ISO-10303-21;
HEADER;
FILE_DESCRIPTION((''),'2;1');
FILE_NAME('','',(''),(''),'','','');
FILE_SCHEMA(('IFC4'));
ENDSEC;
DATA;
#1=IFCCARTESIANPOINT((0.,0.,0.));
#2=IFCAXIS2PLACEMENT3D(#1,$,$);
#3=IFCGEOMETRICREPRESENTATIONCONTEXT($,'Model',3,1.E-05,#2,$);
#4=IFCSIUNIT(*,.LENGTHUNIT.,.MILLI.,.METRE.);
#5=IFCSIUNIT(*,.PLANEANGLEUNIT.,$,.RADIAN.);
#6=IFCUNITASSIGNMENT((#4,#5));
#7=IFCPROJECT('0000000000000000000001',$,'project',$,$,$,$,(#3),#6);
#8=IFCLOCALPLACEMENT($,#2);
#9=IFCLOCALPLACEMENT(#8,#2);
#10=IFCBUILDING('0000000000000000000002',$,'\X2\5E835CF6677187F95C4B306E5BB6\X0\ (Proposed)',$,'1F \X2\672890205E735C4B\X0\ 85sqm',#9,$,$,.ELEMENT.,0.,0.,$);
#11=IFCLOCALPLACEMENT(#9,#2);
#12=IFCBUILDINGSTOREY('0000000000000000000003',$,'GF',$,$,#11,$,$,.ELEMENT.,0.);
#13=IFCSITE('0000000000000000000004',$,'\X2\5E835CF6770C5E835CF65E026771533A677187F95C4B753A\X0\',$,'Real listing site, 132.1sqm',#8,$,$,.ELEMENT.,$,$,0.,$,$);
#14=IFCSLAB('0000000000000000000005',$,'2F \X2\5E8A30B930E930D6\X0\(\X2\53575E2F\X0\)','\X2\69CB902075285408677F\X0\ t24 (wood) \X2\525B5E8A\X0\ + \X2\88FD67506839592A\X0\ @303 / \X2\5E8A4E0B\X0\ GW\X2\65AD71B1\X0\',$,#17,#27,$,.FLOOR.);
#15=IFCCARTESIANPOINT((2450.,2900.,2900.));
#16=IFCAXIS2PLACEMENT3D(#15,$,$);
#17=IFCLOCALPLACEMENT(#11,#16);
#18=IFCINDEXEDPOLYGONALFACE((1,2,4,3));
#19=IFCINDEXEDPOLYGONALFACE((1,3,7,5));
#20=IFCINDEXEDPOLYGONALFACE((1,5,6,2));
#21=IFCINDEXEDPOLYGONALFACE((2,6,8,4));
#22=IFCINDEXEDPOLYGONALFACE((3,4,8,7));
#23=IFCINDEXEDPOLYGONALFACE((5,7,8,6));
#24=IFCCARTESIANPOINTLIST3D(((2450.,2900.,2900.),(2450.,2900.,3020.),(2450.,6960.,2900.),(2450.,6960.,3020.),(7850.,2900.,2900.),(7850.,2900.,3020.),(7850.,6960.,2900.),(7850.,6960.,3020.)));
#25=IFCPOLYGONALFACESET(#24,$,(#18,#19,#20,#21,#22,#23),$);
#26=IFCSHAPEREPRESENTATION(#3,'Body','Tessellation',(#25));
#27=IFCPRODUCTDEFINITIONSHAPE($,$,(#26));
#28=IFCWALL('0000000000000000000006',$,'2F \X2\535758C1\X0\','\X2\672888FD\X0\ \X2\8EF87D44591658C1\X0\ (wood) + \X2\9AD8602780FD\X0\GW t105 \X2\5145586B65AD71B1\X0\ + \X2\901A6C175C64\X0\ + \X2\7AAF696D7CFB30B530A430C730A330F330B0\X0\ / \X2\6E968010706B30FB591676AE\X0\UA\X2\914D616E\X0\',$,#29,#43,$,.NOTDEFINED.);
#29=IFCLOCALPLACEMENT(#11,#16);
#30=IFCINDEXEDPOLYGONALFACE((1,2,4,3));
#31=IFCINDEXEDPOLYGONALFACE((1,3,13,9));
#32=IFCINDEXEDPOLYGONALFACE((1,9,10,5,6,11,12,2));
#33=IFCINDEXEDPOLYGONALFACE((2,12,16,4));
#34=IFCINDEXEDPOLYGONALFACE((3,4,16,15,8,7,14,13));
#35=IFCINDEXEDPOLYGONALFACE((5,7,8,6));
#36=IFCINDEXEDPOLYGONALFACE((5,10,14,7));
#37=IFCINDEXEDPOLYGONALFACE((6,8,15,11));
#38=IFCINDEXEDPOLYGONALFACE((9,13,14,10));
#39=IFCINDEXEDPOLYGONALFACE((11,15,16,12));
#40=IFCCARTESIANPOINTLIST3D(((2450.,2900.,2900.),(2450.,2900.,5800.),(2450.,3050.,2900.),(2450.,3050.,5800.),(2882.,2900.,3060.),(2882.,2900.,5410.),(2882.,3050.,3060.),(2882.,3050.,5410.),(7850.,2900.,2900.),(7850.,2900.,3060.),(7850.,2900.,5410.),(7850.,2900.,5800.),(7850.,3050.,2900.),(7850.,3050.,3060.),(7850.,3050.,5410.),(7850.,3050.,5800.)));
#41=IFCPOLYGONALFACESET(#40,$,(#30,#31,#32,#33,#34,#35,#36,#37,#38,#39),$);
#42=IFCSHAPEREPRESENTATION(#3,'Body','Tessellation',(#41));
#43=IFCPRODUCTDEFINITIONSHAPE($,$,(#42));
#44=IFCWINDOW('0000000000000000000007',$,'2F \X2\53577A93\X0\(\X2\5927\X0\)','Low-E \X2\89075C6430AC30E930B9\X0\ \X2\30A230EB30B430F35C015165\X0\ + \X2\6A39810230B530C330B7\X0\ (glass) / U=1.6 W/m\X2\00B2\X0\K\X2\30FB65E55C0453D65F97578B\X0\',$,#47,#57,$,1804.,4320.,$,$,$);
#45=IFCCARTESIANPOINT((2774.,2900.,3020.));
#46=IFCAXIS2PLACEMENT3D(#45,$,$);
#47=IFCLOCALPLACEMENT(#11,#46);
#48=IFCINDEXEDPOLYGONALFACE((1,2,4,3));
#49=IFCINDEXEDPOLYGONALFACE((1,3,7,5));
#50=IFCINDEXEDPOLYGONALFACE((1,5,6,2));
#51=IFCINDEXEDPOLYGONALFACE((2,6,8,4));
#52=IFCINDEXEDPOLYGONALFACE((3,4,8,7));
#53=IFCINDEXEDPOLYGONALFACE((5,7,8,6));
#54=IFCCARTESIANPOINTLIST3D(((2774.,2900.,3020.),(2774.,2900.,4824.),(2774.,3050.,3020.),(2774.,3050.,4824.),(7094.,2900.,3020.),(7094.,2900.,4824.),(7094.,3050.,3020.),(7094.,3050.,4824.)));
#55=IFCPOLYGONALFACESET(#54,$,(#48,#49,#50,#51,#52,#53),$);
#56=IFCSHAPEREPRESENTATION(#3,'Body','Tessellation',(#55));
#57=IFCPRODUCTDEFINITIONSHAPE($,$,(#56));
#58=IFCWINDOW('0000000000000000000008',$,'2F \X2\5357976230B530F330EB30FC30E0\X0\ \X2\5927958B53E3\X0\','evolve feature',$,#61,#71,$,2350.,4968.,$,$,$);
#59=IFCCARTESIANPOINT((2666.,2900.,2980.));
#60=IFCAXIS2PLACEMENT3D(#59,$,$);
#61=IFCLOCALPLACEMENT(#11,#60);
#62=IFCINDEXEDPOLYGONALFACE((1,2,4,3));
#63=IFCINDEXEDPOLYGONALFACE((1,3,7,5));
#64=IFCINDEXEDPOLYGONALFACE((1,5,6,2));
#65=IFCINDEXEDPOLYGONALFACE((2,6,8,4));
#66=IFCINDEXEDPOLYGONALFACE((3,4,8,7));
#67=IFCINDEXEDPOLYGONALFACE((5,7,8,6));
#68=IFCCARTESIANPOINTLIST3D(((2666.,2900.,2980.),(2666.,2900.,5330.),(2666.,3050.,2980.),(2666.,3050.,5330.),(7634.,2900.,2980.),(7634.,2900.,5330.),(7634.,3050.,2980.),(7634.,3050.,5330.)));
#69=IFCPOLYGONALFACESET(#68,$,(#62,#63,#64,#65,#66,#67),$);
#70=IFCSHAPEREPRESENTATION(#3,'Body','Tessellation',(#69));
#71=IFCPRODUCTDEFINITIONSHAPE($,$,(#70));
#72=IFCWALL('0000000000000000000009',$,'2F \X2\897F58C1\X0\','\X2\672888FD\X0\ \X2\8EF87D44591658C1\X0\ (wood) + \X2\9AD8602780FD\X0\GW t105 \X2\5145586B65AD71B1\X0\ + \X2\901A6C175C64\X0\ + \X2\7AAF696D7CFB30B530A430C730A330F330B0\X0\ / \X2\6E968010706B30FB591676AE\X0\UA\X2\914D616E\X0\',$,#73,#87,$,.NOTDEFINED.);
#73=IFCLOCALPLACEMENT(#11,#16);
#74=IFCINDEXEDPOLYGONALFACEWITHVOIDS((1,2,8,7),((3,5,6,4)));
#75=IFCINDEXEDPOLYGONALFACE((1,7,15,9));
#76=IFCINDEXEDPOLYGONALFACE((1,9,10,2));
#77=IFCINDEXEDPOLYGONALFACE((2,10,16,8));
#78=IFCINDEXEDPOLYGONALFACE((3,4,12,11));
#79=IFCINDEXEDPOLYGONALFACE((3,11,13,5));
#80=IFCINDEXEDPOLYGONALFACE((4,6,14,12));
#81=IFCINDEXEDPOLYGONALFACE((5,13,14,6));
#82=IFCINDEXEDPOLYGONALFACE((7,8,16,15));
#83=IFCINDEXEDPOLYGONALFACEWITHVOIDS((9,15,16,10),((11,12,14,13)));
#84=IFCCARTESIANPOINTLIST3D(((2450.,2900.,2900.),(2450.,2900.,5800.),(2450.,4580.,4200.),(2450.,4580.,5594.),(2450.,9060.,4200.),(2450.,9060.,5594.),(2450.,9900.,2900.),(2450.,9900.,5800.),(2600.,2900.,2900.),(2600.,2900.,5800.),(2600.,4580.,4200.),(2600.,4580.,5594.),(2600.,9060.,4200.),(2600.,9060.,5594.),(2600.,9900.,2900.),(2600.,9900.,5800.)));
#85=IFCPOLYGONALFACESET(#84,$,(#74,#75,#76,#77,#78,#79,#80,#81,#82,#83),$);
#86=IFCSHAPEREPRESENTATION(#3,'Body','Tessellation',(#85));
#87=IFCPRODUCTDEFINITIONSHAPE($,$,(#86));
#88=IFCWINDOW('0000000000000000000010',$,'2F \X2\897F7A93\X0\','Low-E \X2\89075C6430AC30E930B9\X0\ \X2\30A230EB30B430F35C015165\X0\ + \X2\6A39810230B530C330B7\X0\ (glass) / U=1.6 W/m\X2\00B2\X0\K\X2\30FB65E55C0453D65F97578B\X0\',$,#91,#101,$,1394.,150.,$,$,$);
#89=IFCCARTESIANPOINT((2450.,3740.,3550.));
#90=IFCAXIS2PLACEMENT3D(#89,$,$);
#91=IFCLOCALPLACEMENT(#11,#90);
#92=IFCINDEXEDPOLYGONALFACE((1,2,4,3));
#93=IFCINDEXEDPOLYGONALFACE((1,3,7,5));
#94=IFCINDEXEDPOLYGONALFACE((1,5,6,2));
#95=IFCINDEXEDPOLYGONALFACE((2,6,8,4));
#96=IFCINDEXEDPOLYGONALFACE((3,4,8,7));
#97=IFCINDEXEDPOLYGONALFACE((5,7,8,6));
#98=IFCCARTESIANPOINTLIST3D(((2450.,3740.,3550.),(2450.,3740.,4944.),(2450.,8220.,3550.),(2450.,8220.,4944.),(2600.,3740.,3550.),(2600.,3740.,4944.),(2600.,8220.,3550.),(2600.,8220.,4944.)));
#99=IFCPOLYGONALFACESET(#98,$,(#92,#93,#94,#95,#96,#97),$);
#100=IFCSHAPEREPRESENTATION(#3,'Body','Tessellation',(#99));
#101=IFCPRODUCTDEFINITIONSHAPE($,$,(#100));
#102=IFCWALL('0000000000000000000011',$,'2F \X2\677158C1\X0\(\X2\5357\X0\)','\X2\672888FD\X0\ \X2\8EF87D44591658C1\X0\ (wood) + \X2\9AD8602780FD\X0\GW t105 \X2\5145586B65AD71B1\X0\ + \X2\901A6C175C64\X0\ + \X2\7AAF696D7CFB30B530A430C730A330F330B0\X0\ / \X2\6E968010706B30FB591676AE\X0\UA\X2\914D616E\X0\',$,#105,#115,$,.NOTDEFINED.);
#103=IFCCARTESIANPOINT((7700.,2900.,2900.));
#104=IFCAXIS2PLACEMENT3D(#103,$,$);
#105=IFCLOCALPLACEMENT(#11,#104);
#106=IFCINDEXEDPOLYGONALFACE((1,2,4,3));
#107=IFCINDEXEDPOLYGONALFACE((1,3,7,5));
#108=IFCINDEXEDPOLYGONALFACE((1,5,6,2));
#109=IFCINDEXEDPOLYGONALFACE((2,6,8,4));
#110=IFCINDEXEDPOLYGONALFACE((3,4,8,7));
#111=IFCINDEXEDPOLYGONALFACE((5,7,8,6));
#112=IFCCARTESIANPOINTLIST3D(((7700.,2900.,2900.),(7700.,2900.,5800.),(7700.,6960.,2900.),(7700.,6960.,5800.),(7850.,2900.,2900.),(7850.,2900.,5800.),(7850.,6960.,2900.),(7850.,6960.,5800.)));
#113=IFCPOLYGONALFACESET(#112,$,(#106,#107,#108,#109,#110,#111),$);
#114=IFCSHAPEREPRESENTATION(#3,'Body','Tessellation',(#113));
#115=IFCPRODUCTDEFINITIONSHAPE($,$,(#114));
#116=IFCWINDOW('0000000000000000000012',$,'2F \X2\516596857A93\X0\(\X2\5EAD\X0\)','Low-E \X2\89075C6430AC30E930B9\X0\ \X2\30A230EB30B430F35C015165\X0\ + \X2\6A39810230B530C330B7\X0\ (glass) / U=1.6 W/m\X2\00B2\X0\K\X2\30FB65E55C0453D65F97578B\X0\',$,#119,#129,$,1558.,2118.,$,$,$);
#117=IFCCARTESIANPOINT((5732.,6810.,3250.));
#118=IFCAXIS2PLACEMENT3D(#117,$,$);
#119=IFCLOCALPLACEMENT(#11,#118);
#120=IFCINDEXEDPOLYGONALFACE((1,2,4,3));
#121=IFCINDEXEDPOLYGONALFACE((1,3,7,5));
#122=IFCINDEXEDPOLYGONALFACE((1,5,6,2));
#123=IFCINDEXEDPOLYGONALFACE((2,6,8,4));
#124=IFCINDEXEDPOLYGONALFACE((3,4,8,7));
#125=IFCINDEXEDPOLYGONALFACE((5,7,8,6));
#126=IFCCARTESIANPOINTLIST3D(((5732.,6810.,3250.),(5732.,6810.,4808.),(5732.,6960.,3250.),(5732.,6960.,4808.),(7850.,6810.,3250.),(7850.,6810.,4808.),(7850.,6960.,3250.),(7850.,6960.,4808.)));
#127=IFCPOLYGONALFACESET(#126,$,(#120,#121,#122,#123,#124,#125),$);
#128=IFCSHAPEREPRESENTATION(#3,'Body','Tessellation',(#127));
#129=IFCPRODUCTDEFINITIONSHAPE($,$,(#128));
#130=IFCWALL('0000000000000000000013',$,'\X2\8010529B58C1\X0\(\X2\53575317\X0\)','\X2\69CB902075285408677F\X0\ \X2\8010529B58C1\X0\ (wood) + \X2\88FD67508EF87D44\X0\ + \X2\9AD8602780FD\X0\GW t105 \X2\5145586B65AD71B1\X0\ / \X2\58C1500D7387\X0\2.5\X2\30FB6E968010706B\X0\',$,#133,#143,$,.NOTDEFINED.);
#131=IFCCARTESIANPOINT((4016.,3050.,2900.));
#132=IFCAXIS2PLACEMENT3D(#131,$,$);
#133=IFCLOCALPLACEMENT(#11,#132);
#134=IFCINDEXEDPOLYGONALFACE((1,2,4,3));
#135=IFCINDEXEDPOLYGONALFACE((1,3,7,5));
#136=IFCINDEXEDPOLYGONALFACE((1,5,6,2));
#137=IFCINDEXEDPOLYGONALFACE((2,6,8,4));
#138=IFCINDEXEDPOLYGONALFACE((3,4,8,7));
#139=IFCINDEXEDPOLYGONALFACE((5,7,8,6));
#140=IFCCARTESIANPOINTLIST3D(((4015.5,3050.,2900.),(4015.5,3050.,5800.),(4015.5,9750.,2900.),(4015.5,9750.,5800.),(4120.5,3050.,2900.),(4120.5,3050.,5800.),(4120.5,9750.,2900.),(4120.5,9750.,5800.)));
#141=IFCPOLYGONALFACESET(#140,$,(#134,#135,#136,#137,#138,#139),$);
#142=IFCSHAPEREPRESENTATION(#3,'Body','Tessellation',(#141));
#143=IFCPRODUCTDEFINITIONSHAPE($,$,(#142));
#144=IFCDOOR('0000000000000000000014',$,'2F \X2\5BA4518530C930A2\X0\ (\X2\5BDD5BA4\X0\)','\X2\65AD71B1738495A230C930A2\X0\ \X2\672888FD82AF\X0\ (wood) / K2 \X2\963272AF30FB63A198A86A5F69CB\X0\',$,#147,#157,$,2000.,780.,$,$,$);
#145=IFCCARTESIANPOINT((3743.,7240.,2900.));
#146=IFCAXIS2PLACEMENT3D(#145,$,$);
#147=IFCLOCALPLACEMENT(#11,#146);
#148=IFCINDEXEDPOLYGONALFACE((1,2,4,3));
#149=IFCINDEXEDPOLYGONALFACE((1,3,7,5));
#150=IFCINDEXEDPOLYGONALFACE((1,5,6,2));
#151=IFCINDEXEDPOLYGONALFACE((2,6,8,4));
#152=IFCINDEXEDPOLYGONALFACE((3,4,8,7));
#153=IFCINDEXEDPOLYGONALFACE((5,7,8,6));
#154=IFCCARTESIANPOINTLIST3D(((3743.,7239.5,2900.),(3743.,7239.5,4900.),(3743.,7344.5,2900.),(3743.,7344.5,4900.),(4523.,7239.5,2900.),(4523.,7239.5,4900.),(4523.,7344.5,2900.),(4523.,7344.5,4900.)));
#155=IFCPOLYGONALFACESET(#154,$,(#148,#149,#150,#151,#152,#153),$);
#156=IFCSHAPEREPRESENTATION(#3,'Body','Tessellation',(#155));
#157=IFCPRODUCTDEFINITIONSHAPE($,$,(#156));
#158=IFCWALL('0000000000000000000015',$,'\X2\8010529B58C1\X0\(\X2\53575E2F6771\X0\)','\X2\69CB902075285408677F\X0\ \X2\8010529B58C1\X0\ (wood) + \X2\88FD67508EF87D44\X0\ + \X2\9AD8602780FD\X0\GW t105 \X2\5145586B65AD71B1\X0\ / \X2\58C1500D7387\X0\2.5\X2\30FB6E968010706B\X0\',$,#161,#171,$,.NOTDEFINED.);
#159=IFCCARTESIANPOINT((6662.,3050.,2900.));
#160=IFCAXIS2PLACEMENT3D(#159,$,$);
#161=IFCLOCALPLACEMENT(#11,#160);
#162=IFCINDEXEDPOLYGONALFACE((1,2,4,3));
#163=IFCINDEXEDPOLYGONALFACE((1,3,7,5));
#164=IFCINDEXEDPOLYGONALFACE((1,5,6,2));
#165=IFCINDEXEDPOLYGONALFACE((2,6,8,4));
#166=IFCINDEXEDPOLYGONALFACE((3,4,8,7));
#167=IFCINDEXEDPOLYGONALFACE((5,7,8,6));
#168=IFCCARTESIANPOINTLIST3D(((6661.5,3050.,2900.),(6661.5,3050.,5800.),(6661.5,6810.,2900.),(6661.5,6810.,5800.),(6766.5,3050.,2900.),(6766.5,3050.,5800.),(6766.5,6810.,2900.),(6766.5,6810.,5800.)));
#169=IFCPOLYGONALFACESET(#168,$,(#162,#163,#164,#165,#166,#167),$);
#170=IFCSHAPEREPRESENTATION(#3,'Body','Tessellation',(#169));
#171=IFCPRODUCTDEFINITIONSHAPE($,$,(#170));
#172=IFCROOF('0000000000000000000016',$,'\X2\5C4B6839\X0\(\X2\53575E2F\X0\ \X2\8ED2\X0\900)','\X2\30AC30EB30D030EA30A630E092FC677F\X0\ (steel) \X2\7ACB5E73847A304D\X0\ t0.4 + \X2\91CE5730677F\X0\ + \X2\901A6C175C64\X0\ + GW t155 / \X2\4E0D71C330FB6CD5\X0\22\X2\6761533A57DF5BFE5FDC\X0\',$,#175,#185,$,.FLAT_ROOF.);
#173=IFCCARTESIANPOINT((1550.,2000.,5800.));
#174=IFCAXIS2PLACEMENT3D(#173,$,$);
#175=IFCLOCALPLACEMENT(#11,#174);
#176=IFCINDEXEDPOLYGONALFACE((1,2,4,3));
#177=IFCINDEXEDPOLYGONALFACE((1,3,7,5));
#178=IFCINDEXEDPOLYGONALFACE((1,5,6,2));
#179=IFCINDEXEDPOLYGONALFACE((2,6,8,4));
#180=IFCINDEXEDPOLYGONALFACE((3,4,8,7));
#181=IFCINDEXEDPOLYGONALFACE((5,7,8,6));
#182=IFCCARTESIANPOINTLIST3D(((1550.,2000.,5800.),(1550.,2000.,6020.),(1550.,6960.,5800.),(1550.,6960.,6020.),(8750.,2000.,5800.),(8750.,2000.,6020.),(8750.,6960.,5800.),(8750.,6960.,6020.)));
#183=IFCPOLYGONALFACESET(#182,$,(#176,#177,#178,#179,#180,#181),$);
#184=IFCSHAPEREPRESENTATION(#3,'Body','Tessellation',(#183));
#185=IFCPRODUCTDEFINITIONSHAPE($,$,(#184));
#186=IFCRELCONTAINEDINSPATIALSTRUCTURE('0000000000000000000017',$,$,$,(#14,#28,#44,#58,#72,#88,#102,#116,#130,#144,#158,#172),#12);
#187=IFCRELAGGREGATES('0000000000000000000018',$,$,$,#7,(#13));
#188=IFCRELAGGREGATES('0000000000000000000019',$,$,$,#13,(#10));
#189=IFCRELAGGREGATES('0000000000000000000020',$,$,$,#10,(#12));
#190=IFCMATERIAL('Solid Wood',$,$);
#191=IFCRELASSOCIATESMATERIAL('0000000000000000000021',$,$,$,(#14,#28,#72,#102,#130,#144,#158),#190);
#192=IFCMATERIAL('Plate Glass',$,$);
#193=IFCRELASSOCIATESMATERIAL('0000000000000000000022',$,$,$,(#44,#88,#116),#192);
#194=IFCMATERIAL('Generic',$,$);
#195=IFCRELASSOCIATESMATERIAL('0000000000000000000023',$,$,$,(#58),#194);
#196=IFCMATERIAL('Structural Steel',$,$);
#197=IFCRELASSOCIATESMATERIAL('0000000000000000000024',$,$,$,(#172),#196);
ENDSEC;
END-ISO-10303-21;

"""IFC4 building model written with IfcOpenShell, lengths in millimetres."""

from ifc_helpers import new_model, si_unit, frame, frame_2d, origin, place, context, project, spatial, rectangle, extrude, material, element, fill, save


model = new_model("IFC4")

# Units and contexts
model_context = context("Model", 3, precision=1e-05, world=origin())
ifc_project = project(units=[si_unit("LENGTHUNIT", "METRE", prefix="MILLI"), si_unit("PLANEANGLEUNIT", "RADIAN")], contexts=[model_context])

# Site, building, storey
site_placement = place(None, origin())
site = spatial("IfcSite", under=ifc_project, at=site_placement, Name="広島県広島市東区東蟹屋町", ObjectType="Real listing site, 132.1sqm", CompositionType="ELEMENT", RefElevation=0.0)
building_placement = place(site_placement, origin())
building = spatial("IfcBuilding", under=site, at=building_placement, Name="広島東蟹屋の家 (Proposed)", ObjectType="1F 木造平屋 85sqm", CompositionType="ELEMENT", ElevationOfRefHeight=0.0, ElevationOfTerrain=0.0)
storey_placement = place(building_placement, origin())
storey = spatial("IfcBuildingStorey", under=building, at=storey_placement, Name="GF", CompositionType="ELEMENT", Elevation=0.0)

# Slab
ifc_material_1 = material(Name="Solid Wood")
slab_placement = place(storey_placement, frame((2450.0, 2900.0, 2900.0)))
element("IfcSlab", 1, at=slab_placement, inside=storey, material=ifc_material_1, Name="2F 床スラブ(南帯)", Description="構造用合板 t24 (wood) 剛床 + 製材根太 @303 / 床下 GW断熱", PredefinedType="FLOOR", context=model_context, shape_type="SweptSolid", body=[
    extrude(rectangle(XDim=5400.0, YDim=4060.0, at=frame_2d((2700.0, 2030.0))), frame((2450.0, 2900.0, 2900.0)), (0.0, 0.0, 1.0), 120.0),
])

# Wall, openings, windows
wall_1_placement = place(storey_placement, frame((2450.0, 2900.0, 2900.0)))
wall_1 = element("IfcWall", 2, at=wall_1_placement, inside=storey, material=ifc_material_1, Name="2F 南壁", Description="木製 軸組外壁 (wood) + 高性能GW t105 充填断熱 + 通気層 + 窯業系サイディング / 準耐火・外皮UA配慮", PredefinedType="NOTDEFINED", context=model_context, shape_type="SweptSolid", body=[
    extrude(rectangle(XDim=5400.0, YDim=150.0, at=frame_2d((2700.0, 75.0))), frame((2450.0, 2900.0, 2900.0)), (0.0, 0.0, 1.0), 2900.0),
])
opening_1_placement = place(storey_placement, frame((2774.0, 2900.0, 3020.0)))
opening_1 = element("IfcOpeningElement", 3, at=opening_1_placement, cuts=wall_1, PredefinedType="NOTDEFINED", context=model_context, shape_type="SweptSolid", body=[
    extrude(rectangle(XDim=4320.0, YDim=150.0, at=frame_2d((2160.0, 75.0))), frame((2774.0, 2900.0, 3020.0)), (0.0, 0.0, 1.0), 1804.0),
])
opening_2_placement = place(storey_placement, frame((2666.0, 2900.0, 2980.0)))
opening_2 = element("IfcOpeningElement", 4, at=opening_2_placement, cuts=wall_1, PredefinedType="NOTDEFINED", context=model_context, shape_type="SweptSolid", body=[
    extrude(rectangle(XDim=4968.0, YDim=150.0, at=frame_2d((2484.0, 75.0))), frame((2666.0, 2900.0, 2980.0)), (0.0, 0.0, 1.0), 2350.0),
])
ifc_material_2 = material(Name="Plate Glass")
window_1_placement = place(storey_placement, frame((2774.0, 2900.0, 3020.0)))
window_1 = element("IfcWindow", 5, at=window_1_placement, inside=storey, material=ifc_material_2, Name="2F 南窓(大)", Description="Low-E 複層ガラス アルゴン封入 + 樹脂サッシ (glass) / U=1.6 W/m²K・日射取得型", OverallHeight=1804.0, OverallWidth=4320.0, context=model_context, shape_type="SweptSolid", body=[
    extrude(rectangle(XDim=4320.0, YDim=150.0, at=frame_2d((2160.0, 75.0))), frame((2774.0, 2900.0, 3020.0)), (0.0, 0.0, 1.0), 1804.0),
])
fill(opening_1, window_1)
ifc_material_3 = material(Name="Generic")
window_2_placement = place(storey_placement, frame((2666.0, 2900.0, 2980.0)))
window_2 = element("IfcWindow", 6, at=window_2_placement, inside=storey, material=ifc_material_3, Name="2F 南面サンルーム 大開口", Description="evolve feature", OverallHeight=2350.0, OverallWidth=4968.0, context=model_context, shape_type="SweptSolid", body=[
    extrude(rectangle(XDim=4968.0, YDim=150.0, at=frame_2d((2484.0, 75.0))), frame((2666.0, 2900.0, 2980.0)), (0.0, 0.0, 1.0), 2350.0),
])
fill(opening_2, window_2)

# Walls, openings, windows
wall_2_placement = place(storey_placement, frame((2450.0, 2900.0, 2900.0)))
wall_2 = element("IfcWall", 7, at=wall_2_placement, inside=storey, material=ifc_material_1, Name="2F 西壁", Description="木製 軸組外壁 (wood) + 高性能GW t105 充填断熱 + 通気層 + 窯業系サイディング / 準耐火・外皮UA配慮", PredefinedType="NOTDEFINED", context=model_context, shape_type="SweptSolid", body=[
    extrude(rectangle(XDim=150.0, YDim=7000.0, at=frame_2d((75.0, 3500.0))), frame((2450.0, 2900.0, 2900.0)), (0.0, 0.0, 1.0), 2900.0),
])
opening_3_placement = place(storey_placement, frame((2450.0, 3740.0, 3550.0)))
opening_3 = element("IfcOpeningElement", 8, at=opening_3_placement, cuts=wall_2, PredefinedType="NOTDEFINED", context=model_context, shape_type="SweptSolid", body=[
    extrude(rectangle(XDim=150.0, YDim=4480.0, at=frame_2d((75.0, 2240.0))), frame((2450.0, 3740.0, 3550.0)), (0.0, 0.0, 1.0), 1394.0),
])
window_3_placement = place(storey_placement, frame((2450.0, 3740.0, 3550.0)))
window_3 = element("IfcWindow", 9, at=window_3_placement, inside=storey, material=ifc_material_2, Name="2F 西窓", Description="Low-E 複層ガラス アルゴン封入 + 樹脂サッシ (glass) / U=1.6 W/m²K・日射取得型", OverallHeight=1394.0, OverallWidth=150.0, context=model_context, shape_type="SweptSolid", body=[
    extrude(rectangle(XDim=150.0, YDim=4480.0, at=frame_2d((75.0, 2240.0))), frame((2450.0, 3740.0, 3550.0)), (0.0, 0.0, 1.0), 1394.0),
])
fill(opening_3, window_3)
wall_3_placement = place(storey_placement, frame((7700.0, 2900.0, 2900.0)))
wall_3 = element("IfcWall", 10, at=wall_3_placement, inside=storey, material=ifc_material_1, Name="2F 東壁(南)", Description="木製 軸組外壁 (wood) + 高性能GW t105 充填断熱 + 通気層 + 窯業系サイディング / 準耐火・外皮UA配慮", PredefinedType="NOTDEFINED", context=model_context, shape_type="SweptSolid", body=[
    extrude(rectangle(XDim=150.0, YDim=4060.0, at=frame_2d((75.0, 2030.0))), frame((7700.0, 2900.0, 2900.0)), (0.0, 0.0, 1.0), 2900.0),
])
opening_4_placement = place(storey_placement, frame((5732.0, 6810.0, 3250.0)))
opening_4 = element("IfcOpeningElement", 11, at=opening_4_placement, cuts=wall_3, PredefinedType="NOTDEFINED", context=model_context, shape_type="SweptSolid", body=[
    extrude(rectangle(XDim=2118.0, YDim=150.0, at=frame_2d((1059.0, 75.0))), frame((5732.0, 6810.0, 3250.0)), (0.0, 0.0, 1.0), 1558.0),
])
window_4_placement = place(storey_placement, frame((5732.0, 6810.0, 3250.0)))
window_4 = element("IfcWindow", 12, at=window_4_placement, inside=storey, material=ifc_material_2, Name="2F 入隅窓(庭)", Description="Low-E 複層ガラス アルゴン封入 + 樹脂サッシ (glass) / U=1.6 W/m²K・日射取得型", OverallHeight=1558.0, OverallWidth=2118.0, context=model_context, shape_type="SweptSolid", body=[
    extrude(rectangle(XDim=2118.0, YDim=150.0, at=frame_2d((1059.0, 75.0))), frame((5732.0, 6810.0, 3250.0)), (0.0, 0.0, 1.0), 1558.0),
])
fill(opening_4, window_4)

# Wall, opening, door
wall_4_placement = place(storey_placement, frame((4016.0, 3050.0, 2900.0)))
wall_4 = element("IfcWall", 13, at=wall_4_placement, inside=storey, material=ifc_material_1, Name="耐力壁(南北)", Description="構造用合板 耐力壁 (wood) + 製材軸組 + 高性能GW t105 充填断熱 / 壁倍率2.5・準耐火", PredefinedType="NOTDEFINED", context=model_context, shape_type="SweptSolid", body=[
    extrude(rectangle(XDim=105.0, YDim=6700.0, at=frame_2d((52.0, 3350.0))), frame((4016.0, 3050.0, 2900.0)), (0.0, 0.0, 1.0), 2900.0),
])
opening_5_placement = place(storey_placement, frame((3743.0, 7240.0, 2900.0)))
opening_5 = element("IfcOpeningElement", 14, at=opening_5_placement, cuts=wall_4, PredefinedType="NOTDEFINED", context=model_context, shape_type="SweptSolid", body=[
    extrude(rectangle(XDim=780.0, YDim=105.0, at=frame_2d((390.0, 52.0))), frame((3743.0, 7240.0, 2900.0)), (0.0, 0.0, 1.0), 2000.0),
])
door_placement = place(storey_placement, frame((3743.0, 7240.0, 2900.0)))
door = element("IfcDoor", 15, at=door_placement, inside=storey, material=ifc_material_1, Name="2F 室内ドア (寝室)", Description="断熱玄関ドア 木製芯 (wood) / K2 防犯・採風機構", OverallHeight=2000.0, OverallWidth=780.0, context=model_context, shape_type="SweptSolid", body=[
    extrude(rectangle(XDim=780.0, YDim=105.0, at=frame_2d((390.0, 52.0))), frame((3743.0, 7240.0, 2900.0)), (0.0, 0.0, 1.0), 2000.0),
])
fill(opening_5, door)

# Wall
wall_5_placement = place(storey_placement, frame((6662.0, 3050.0, 2900.0)))
element("IfcWall", 16, at=wall_5_placement, inside=storey, material=ifc_material_1, Name="耐力壁(南帯東)", Description="構造用合板 耐力壁 (wood) + 製材軸組 + 高性能GW t105 充填断熱 / 壁倍率2.5・準耐火", PredefinedType="NOTDEFINED", context=model_context, shape_type="SweptSolid", body=[
    extrude(rectangle(XDim=105.0, YDim=3760.0, at=frame_2d((52.0, 1880.0))), frame((6662.0, 3050.0, 2900.0)), (0.0, 0.0, 1.0), 2900.0),
])

# Roof
ifc_material_4 = material(Name="Structural Steel")
for number, where, name in (
    (17, (1550.0, 2000.0, 5800.0), "屋根(南帯 軒900)"),
):
    element("IfcRoof", number, at=place(storey_placement, frame(where)), inside=storey, material=ifc_material_4, Name=name, Description="ガルバリウム鋼板 (steel) 立平葺き t0.4 + 野地板 + 通気層 + GW t155 / 不燃・法22条区域対応", PredefinedType="FLAT_ROOF", context=model_context, shape_type="SweptSolid", body=[
        extrude(rectangle(XDim=7200.0, YDim=4960.0, at=frame_2d((3600.0, 2480.0))), frame((1550.0, 2000.0, 5800.0)), (0.0, 0.0, 1.0), 220.0),
    ])

save(model, "model.ifc")
